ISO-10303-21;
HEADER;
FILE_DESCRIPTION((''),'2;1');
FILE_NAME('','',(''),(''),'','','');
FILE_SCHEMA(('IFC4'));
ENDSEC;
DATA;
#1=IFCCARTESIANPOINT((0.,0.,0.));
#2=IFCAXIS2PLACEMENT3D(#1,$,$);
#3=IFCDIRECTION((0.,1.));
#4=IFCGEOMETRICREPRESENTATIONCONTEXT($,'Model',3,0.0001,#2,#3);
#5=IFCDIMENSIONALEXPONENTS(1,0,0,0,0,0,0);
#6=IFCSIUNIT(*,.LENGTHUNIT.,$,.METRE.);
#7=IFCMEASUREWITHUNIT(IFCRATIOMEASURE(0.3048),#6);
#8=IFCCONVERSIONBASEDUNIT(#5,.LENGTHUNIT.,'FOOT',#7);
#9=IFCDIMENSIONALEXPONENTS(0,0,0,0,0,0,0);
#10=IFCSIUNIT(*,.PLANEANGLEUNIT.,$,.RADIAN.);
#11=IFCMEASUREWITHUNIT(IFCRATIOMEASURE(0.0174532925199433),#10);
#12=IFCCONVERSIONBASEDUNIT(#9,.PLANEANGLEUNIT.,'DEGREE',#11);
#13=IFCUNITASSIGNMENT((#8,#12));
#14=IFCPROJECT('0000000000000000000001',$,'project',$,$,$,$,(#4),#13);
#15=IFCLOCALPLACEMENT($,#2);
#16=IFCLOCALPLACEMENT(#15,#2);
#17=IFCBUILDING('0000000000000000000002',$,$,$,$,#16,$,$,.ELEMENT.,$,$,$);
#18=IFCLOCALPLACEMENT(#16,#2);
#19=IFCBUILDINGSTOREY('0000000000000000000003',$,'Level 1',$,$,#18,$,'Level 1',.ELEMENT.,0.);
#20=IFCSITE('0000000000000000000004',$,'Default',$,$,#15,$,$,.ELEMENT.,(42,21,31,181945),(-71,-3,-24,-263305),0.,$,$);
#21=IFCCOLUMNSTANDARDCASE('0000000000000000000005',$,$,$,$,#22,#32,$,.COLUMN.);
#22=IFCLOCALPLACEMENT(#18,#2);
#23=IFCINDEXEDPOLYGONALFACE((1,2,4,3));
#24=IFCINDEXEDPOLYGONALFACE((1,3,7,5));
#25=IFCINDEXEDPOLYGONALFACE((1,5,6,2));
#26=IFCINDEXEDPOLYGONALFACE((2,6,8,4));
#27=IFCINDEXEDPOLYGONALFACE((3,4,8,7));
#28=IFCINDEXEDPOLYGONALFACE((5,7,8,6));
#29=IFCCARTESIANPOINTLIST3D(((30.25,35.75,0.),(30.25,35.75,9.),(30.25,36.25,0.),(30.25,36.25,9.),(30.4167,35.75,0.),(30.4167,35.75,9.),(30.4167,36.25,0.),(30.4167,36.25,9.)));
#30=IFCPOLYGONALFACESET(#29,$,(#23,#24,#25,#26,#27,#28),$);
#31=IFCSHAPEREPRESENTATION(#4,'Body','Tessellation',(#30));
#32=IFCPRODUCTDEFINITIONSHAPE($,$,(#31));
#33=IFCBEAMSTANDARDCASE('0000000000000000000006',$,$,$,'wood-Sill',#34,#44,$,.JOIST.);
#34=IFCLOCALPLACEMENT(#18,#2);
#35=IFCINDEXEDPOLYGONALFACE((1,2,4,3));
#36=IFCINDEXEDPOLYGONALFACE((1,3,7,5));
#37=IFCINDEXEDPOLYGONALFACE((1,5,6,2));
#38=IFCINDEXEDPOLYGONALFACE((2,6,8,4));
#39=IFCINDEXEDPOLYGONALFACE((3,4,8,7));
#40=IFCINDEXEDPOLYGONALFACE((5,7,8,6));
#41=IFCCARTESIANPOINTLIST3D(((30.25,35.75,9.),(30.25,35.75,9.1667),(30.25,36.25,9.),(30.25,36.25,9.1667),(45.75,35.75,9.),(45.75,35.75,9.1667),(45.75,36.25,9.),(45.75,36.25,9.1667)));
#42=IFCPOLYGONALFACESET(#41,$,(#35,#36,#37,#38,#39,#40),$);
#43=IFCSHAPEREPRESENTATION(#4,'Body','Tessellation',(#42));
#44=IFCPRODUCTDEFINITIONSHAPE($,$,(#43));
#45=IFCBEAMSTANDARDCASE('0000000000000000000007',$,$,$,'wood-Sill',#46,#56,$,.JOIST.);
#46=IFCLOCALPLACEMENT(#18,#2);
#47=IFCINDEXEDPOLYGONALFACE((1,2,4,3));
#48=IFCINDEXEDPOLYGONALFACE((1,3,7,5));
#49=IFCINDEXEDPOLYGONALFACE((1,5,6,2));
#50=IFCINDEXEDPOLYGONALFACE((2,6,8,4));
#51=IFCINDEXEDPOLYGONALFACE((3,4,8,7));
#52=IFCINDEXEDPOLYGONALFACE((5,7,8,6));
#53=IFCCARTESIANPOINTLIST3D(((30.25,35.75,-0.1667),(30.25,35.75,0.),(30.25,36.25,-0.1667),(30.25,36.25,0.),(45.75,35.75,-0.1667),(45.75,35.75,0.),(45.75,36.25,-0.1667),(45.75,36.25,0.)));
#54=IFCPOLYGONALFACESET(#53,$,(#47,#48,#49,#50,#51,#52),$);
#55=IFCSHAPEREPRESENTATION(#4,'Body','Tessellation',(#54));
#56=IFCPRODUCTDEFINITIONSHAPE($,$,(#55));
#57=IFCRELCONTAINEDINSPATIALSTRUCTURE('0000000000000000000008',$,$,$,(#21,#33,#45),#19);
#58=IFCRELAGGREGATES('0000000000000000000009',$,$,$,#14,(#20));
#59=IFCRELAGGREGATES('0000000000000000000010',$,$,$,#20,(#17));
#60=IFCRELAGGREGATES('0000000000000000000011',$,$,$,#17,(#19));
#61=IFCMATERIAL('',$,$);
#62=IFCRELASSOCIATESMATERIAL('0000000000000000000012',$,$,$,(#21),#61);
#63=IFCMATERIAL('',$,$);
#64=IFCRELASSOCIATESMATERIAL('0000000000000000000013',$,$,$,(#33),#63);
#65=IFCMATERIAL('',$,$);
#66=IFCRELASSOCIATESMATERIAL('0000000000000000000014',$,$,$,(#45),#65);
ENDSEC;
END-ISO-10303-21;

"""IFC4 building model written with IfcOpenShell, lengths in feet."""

from ifc_helpers import new_model, entity, si_unit, converted_unit, direction, frame, origin, place, context, project, spatial, rectangle, extrude, material, element, save


model = new_model("IFC4")

# Units and contexts
model_context = context("Model", 3, precision=0.0001, world=origin(), true_north=direction((0.0, 1.0)))
ifc_project = project(units=[converted_unit("LENGTHUNIT", "FOOT", entity("IfcRatioMeasure", 0.3048), si_unit("LENGTHUNIT", "METRE"), dimensions=[1, 0, 0, 0, 0, 0, 0]), converted_unit("PLANEANGLEUNIT", "DEGREE", entity("IfcRatioMeasure", 0.0174532925199433), si_unit("PLANEANGLEUNIT", "RADIAN"), dimensions=[0, 0, 0, 0, 0, 0, 0])], contexts=[model_context])

# Site, building, storey
site_placement = place(None, origin())
site = spatial("IfcSite", under=ifc_project, at=site_placement, Name="Default", CompositionType="ELEMENT", RefLatitude=(42, 21, 31, 181945), RefLongitude=(-71, -3, -24, -263305), RefElevation=0.0)
building_placement = place(site_placement, origin())
building = spatial("IfcBuilding", under=site, at=building_placement, CompositionType="ELEMENT")
storey_placement = place(building_placement, origin())
storey = spatial("IfcBuildingStorey", under=building, at=storey_placement, Name="Level 1", LongName="Level 1", CompositionType="ELEMENT", Elevation=0.0)

# Column
ifc_material_1 = material(Name="")
placement_1 = place(storey_placement, frame((30.25, 36.0, 0.0)))
for number, where, z_axis, x_axis in (
    (1, (0.0833, 0.0, 0.0), (0.0, 0.0, 1.0), (1.0, 0.0, 0.0)),
):
    element("IfcColumnStandardCase", number, at=place(placement_1, frame(where, z_axis=z_axis, x_axis=x_axis)), inside=storey, material=ifc_material_1, PredefinedType="COLUMN", context=model_context, shape_type="SweptSolid", body=[
        extrude(rectangle(XDim=0.1667, YDim=0.5), origin(), (0.0, 0.0, 1.0), 9.0),
    ])

# Beams
ifc_material_2 = material(Name="")
beam_1_placement = place(placement_1, frame((7.75, 0.0, 9.0), z_axis=(0.0, 0.0, 1.0), x_axis=(1.0, 0.0, 0.0)))
element("IfcBeamStandardCase", 2, at=beam_1_placement, inside=storey, material=ifc_material_2, ObjectType="wood-Sill", PredefinedType="JOIST", context=model_context, shape_type="SweptSolid", body=[
    extrude(rectangle(XDim=15.5, YDim=0.5), origin(), (0.0, 0.0, 1.0), 0.1667),
])
ifc_material_3 = material(Name="")
beam_2_placement = place(placement_1, frame((7.75, 0.0, -0.1667), z_axis=(0.0, 0.0, 1.0), x_axis=(1.0, 0.0, 0.0)))
element("IfcBeamStandardCase", 3, at=beam_2_placement, inside=storey, material=ifc_material_3, ObjectType="wood-Sill", PredefinedType="JOIST", context=model_context, shape_type="SweptSolid", body=[
    extrude(rectangle(XDim=15.5, YDim=0.5), origin(), (0.0, 0.0, 1.0), 0.1667),
])

save(model, "model.ifc")
